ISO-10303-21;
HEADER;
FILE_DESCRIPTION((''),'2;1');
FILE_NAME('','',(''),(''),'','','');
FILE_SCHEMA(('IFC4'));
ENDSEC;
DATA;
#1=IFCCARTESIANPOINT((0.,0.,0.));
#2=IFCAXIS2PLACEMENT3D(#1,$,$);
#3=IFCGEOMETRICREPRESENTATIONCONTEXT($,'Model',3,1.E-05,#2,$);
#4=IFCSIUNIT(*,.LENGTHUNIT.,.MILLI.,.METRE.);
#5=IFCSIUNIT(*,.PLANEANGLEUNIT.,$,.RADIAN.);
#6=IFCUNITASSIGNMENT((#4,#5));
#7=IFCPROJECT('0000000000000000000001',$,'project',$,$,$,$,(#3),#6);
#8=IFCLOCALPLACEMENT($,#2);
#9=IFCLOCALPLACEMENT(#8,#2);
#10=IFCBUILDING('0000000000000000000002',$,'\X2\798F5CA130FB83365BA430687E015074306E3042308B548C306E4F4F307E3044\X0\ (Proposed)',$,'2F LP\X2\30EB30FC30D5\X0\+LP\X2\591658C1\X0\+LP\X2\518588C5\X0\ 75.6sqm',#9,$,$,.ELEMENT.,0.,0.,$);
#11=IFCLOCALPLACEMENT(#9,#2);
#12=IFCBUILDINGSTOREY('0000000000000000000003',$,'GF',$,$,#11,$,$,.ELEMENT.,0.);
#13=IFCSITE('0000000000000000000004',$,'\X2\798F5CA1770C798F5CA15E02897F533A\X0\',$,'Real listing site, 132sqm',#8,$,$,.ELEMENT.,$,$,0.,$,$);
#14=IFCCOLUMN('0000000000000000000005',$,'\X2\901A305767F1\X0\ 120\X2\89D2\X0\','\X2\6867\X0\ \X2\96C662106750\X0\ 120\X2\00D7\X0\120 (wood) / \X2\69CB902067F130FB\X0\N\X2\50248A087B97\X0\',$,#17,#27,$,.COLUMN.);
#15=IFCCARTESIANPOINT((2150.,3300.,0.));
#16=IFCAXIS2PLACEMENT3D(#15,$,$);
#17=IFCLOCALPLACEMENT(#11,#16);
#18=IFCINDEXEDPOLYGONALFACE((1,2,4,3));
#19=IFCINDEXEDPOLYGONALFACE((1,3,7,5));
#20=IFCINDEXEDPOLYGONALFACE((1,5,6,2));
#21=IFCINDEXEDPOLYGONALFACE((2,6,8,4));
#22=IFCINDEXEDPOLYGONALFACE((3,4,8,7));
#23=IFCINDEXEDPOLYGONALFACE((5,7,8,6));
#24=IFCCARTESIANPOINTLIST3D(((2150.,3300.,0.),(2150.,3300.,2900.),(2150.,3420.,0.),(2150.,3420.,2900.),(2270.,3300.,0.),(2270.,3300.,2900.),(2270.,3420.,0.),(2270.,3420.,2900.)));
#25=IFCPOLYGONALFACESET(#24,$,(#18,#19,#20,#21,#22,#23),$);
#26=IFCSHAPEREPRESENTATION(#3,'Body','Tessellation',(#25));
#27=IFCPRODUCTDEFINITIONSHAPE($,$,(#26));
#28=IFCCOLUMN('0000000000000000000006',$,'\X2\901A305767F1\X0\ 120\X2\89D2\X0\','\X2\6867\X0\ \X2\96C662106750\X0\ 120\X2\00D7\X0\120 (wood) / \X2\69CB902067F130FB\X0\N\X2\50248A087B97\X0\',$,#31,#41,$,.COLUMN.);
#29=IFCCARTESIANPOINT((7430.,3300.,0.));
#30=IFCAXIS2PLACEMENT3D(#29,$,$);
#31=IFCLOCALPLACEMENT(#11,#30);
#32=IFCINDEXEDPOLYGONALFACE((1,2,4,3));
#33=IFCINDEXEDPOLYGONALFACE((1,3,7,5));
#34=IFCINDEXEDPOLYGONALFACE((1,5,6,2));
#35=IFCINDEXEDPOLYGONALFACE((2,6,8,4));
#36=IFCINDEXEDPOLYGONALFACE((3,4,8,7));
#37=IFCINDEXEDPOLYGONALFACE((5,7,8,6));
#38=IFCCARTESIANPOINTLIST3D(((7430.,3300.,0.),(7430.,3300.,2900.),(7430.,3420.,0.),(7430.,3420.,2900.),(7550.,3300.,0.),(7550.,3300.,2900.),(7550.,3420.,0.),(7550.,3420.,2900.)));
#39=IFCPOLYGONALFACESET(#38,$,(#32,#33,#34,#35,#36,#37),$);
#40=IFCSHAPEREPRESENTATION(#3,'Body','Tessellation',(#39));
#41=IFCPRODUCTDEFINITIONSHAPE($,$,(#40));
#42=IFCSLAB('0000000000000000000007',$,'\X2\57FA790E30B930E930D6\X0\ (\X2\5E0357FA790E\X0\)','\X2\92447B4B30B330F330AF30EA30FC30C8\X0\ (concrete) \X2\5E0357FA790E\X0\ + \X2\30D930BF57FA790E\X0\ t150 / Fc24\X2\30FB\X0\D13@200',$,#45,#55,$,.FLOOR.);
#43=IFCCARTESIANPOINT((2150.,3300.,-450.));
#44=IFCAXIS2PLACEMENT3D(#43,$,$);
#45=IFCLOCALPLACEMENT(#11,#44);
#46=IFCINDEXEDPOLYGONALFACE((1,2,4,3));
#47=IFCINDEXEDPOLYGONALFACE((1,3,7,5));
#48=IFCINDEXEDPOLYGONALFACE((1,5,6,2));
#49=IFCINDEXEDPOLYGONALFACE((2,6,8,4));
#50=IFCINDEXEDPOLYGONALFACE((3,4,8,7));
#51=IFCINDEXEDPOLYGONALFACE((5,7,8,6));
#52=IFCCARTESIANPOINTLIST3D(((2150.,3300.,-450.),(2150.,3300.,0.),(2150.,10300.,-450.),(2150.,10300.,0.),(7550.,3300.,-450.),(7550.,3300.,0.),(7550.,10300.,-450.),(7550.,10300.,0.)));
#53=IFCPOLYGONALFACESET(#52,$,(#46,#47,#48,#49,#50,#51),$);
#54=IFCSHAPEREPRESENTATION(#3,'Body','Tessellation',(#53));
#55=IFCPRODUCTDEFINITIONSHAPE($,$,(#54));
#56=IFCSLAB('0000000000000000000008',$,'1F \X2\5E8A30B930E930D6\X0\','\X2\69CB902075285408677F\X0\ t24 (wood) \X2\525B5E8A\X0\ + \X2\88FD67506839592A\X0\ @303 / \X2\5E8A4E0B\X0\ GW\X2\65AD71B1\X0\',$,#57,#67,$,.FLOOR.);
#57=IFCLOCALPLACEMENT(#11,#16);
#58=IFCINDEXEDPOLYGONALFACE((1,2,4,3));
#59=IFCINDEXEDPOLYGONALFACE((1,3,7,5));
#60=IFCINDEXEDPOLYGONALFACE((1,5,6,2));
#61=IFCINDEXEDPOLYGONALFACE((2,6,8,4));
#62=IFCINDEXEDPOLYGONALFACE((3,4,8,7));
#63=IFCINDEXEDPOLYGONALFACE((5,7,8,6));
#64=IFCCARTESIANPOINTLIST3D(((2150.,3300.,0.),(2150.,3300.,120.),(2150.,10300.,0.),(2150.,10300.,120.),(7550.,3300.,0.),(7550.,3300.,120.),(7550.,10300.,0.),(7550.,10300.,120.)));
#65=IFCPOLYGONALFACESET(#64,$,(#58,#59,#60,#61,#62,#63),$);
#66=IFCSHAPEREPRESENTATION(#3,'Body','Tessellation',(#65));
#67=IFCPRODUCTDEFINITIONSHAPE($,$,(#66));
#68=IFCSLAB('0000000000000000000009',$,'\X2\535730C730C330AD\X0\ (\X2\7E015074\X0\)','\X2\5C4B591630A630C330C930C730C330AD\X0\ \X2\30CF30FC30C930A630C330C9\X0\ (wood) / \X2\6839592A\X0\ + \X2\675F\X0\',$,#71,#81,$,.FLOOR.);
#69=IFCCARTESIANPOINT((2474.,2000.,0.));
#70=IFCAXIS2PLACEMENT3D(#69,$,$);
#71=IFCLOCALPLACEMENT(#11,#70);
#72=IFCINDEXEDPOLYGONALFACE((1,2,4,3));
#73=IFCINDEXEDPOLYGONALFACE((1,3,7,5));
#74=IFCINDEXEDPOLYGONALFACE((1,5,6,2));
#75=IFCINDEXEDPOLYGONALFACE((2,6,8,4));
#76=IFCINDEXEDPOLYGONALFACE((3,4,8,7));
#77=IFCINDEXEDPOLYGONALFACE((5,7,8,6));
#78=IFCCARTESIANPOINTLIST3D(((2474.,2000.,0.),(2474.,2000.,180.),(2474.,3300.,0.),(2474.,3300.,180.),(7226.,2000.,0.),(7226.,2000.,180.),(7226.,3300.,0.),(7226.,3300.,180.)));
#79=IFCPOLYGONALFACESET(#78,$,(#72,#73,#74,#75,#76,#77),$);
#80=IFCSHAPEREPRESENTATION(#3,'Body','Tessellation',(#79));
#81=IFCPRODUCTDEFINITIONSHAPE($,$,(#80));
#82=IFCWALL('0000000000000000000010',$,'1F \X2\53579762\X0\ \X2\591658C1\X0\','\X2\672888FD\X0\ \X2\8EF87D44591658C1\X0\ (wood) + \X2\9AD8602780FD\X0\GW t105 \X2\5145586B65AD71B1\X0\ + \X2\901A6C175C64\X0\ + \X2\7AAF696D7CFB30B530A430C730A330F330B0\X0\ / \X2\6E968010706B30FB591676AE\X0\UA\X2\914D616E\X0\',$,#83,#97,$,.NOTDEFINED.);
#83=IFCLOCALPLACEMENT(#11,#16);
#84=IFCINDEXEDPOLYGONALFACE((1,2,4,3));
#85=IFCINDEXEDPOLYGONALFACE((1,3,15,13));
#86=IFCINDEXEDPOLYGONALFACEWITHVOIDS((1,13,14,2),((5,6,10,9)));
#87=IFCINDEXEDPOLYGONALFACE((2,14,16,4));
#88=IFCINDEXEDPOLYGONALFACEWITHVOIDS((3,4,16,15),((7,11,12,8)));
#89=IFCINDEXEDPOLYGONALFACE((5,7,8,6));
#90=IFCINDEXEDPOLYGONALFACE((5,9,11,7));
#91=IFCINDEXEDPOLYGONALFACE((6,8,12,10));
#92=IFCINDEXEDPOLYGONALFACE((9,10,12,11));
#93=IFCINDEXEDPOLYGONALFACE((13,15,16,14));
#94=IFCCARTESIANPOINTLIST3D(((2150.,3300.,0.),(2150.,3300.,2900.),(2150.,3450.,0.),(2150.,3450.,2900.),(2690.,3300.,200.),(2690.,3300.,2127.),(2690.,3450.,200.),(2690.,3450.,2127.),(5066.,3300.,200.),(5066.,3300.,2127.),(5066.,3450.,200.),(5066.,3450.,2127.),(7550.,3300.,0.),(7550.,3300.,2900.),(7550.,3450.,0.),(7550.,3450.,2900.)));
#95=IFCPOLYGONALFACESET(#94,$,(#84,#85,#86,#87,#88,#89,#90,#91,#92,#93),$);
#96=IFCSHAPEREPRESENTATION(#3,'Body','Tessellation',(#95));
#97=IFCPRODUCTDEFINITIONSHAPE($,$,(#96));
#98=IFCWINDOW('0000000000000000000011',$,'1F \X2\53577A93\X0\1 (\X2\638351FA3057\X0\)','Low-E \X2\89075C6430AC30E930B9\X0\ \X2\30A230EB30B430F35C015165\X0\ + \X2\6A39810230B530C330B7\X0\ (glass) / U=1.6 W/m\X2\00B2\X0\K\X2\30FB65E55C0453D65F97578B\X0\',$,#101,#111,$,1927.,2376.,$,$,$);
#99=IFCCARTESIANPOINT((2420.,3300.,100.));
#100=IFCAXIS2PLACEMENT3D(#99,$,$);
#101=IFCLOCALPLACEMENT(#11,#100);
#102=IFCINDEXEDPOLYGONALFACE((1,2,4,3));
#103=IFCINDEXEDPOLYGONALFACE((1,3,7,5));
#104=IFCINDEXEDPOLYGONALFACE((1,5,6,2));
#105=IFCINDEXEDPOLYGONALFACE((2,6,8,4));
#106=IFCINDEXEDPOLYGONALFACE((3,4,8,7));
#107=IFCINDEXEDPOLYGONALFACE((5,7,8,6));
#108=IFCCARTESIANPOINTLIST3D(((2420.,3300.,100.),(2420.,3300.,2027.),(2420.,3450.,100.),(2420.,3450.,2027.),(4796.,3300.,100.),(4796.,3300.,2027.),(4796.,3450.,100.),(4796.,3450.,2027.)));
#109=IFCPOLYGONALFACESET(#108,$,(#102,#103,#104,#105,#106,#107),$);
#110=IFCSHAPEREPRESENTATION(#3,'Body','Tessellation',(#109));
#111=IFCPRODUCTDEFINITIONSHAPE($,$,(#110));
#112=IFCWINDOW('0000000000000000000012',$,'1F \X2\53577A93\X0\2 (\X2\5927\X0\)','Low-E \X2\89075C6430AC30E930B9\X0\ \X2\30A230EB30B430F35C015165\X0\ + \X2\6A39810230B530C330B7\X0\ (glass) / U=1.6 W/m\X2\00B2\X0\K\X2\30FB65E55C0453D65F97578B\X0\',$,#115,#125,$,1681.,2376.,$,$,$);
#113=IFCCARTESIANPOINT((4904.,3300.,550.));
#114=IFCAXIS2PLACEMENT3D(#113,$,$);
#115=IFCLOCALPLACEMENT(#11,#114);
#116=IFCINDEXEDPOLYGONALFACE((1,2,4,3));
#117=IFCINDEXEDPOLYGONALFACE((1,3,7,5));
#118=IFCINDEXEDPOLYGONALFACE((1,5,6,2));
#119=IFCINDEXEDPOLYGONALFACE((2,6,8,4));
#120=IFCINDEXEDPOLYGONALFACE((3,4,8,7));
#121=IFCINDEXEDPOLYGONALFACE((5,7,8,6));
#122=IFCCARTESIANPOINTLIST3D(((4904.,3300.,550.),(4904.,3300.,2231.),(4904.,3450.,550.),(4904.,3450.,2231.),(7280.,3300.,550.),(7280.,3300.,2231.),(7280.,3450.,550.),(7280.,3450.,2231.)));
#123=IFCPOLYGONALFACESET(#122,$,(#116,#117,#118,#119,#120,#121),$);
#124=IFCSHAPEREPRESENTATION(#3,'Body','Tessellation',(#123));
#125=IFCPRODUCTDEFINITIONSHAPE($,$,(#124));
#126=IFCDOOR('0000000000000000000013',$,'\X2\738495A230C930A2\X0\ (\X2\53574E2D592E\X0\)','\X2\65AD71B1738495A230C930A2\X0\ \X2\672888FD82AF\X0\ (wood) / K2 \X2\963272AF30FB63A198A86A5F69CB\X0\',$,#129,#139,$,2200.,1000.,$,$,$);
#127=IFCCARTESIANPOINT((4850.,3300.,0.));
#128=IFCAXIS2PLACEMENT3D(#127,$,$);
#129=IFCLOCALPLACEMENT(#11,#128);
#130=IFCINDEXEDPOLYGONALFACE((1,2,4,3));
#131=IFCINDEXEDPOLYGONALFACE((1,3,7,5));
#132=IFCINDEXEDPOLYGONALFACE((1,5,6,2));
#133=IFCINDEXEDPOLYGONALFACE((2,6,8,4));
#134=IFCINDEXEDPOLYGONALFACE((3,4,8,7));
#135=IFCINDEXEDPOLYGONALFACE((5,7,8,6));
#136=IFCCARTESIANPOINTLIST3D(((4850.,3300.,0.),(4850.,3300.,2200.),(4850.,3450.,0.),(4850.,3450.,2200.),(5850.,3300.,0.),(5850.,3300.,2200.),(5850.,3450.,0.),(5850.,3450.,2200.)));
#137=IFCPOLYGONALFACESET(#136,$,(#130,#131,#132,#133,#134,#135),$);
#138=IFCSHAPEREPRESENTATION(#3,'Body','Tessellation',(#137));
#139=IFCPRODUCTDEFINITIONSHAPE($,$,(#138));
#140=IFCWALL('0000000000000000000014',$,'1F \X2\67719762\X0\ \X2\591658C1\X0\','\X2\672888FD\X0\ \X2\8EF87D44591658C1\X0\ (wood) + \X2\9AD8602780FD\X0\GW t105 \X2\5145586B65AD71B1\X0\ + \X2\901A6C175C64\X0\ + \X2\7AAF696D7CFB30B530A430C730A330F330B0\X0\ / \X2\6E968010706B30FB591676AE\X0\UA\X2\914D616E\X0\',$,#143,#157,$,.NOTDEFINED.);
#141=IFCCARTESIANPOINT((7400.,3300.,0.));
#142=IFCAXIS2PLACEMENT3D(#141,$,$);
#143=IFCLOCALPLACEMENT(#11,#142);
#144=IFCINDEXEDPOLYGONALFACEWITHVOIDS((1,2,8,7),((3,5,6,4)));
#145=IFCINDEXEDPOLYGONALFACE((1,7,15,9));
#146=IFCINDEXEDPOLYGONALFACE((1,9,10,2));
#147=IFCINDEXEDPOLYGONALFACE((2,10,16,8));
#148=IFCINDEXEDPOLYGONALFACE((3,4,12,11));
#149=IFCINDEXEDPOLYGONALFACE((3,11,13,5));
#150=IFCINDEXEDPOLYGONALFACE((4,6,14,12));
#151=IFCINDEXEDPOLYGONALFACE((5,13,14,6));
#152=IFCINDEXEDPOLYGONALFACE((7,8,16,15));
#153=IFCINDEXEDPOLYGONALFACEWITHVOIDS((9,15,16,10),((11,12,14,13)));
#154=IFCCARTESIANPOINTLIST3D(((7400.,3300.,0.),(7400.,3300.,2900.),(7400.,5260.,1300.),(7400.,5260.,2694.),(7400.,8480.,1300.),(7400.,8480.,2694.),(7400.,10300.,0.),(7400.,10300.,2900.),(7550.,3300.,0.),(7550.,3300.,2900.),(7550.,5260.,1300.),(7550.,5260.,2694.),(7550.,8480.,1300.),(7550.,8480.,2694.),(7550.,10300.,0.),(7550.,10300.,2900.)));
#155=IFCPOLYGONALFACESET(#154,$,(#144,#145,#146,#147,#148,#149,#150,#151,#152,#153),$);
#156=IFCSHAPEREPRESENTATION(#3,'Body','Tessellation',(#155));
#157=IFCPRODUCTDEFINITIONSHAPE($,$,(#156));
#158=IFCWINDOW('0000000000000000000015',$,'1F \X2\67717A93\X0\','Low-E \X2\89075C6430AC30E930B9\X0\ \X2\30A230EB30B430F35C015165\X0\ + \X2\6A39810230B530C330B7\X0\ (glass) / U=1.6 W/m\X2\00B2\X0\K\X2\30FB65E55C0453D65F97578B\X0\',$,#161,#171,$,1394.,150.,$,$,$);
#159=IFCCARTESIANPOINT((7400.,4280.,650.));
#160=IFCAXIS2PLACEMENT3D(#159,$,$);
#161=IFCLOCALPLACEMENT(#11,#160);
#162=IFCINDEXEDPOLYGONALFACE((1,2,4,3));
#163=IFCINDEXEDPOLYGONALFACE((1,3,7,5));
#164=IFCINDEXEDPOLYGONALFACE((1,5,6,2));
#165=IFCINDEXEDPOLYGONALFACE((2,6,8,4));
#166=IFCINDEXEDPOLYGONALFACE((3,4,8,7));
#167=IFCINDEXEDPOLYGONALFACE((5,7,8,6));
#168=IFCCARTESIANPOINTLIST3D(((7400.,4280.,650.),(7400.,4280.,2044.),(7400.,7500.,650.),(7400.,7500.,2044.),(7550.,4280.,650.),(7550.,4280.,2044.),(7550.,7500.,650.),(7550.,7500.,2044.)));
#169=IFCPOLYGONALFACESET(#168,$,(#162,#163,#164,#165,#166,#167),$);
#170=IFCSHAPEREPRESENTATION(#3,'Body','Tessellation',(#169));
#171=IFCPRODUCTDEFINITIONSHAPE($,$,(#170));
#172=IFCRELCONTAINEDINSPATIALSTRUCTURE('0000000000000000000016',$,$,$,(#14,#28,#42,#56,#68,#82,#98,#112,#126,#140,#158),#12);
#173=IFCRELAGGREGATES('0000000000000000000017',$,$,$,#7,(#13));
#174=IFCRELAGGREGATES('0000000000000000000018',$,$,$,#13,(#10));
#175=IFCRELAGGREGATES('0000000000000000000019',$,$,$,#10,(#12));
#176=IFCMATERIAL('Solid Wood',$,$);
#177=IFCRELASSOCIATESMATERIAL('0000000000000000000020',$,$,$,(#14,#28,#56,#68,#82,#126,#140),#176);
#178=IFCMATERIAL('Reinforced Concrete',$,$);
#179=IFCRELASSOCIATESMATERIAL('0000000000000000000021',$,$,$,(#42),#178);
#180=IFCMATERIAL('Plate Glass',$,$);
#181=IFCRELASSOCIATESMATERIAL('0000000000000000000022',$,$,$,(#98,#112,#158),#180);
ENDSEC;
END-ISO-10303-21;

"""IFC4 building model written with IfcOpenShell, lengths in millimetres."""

from ifc_helpers import new_model, si_unit, frame, frame_2d, origin, place, context, project, spatial, rectangle, extrude, material, element, fill, save


model = new_model("IFC4")

# Units and contexts
model_context = context("Model", 3, precision=1e-05, world=origin())
ifc_project = project(units=[si_unit("LENGTHUNIT", "METRE", prefix="MILLI"), si_unit("PLANEANGLEUNIT", "RADIAN")], contexts=[model_context])

# Site, building, storey
site_placement = place(None, origin())
site = spatial("IfcSite", under=ifc_project, at=site_placement, Name="福岡県福岡市西区", ObjectType="Real listing site, 132sqm", CompositionType="ELEMENT", RefElevation=0.0)
building_placement = place(site_placement, origin())
building = spatial("IfcBuilding", under=site, at=building_placement, Name="福岡・茶室と縁側のある和の住まい (Proposed)", ObjectType="2F LPルーフ+LP外壁+LP内装 75.6sqm", CompositionType="ELEMENT", ElevationOfRefHeight=0.0, ElevationOfTerrain=0.0)
storey_placement = place(building_placement, origin())
storey = spatial("IfcBuildingStorey", under=building, at=storey_placement, Name="GF", CompositionType="ELEMENT", Elevation=0.0)

# Columns
ifc_material_1 = material(Name="Solid Wood")
column_1_placement = place(storey_placement, frame((2150.0, 3300.0, 0.0)))
element("IfcColumn", 1, at=column_1_placement, inside=storey, material=ifc_material_1, Name="通し柱 120角", Description="桧 集成材 120×120 (wood) / 構造柱・N値計算", PredefinedType="COLUMN", context=model_context, shape_type="SweptSolid", body=[
    extrude(rectangle(XDim=120.0, YDim=120.0, at=frame_2d((60.0, 60.0))), frame((2150.0, 3300.0, 0.0)), (0.0, 0.0, 1.0), 2900.0),
])
column_2_placement = place(storey_placement, frame((7430.0, 3300.0, 0.0)))
element("IfcColumn", 2, at=column_2_placement, inside=storey, material=ifc_material_1, Name="通し柱 120角", Description="桧 集成材 120×120 (wood) / 構造柱・N値計算", PredefinedType="COLUMN", context=model_context, shape_type="SweptSolid", body=[
    extrude(rectangle(XDim=120.0, YDim=120.0, at=frame_2d((60.0, 60.0))), frame((7430.0, 3300.0, 0.0)), (0.0, 0.0, 1.0), 2900.0),
])

# Slabs
ifc_material_2 = material(Name="Reinforced Concrete")
slab_1_placement = place(storey_placement, frame((2150.0, 3300.0, -450.0)))
element("IfcSlab", 3, at=slab_1_placement, inside=storey, material=ifc_material_2, Name="基礎スラブ (布基礎)", Description="鉄筋コンクリート (concrete) 布基礎 + ベタ基礎 t150 / Fc24・D13@200", PredefinedType="FLOOR", context=model_context, shape_type="SweptSolid", body=[
    extrude(rectangle(XDim=5400.0, YDim=7000.0, at=frame_2d((2700.0, 3500.0))), frame((2150.0, 3300.0, -450.0)), (0.0, 0.0, 1.0), 450.0),
])
slab_2_placement = place(storey_placement, frame((2150.0, 3300.0, 0.0)))
element("IfcSlab", 4, at=slab_2_placement, inside=storey, material=ifc_material_1, Name="1F 床スラブ", Description="構造用合板 t24 (wood) 剛床 + 製材根太 @303 / 床下 GW断熱", PredefinedType="FLOOR", context=model_context, shape_type="SweptSolid", body=[
    extrude(rectangle(XDim=5400.0, YDim=7000.0, at=frame_2d((2700.0, 3500.0))), frame((2150.0, 3300.0, 0.0)), (0.0, 0.0, 1.0), 120.0),
])
slab_3_placement = place(storey_placement, frame((2474.0, 2000.0, 0.0)))
element("IfcSlab", 5, at=slab_3_placement, inside=storey, material=ifc_material_1, Name="南デッキ (縁側)", Description="屋外ウッドデッキ ハードウッド (wood) / 根太 + 束", PredefinedType="FLOOR", context=model_context, shape_type="SweptSolid", body=[
    extrude(rectangle(XDim=4752.0, YDim=1300.0, at=frame_2d((2376.0, 650.0))), frame((2474.0, 2000.0, 0.0)), (0.0, 0.0, 1.0), 180.0),
])

# Wall, openings, windows, door
wall_1_placement = place(storey_placement, frame((2150.0, 3300.0, 0.0)))
wall_1 = element("IfcWall", 6, at=wall_1_placement, inside=storey, material=ifc_material_1, Name="1F 南面 外壁", Description="木製 軸組外壁 (wood) + 高性能GW t105 充填断熱 + 通気層 + 窯業系サイディング / 準耐火・外皮UA配慮", PredefinedType="NOTDEFINED", context=model_context, shape_type="SweptSolid", body=[
    extrude(rectangle(XDim=5400.0, YDim=150.0, at=frame_2d((2700.0, 75.0))), frame((2150.0, 3300.0, 0.0)), (0.0, 0.0, 1.0), 2900.0),
])
opening_1_placement = place(storey_placement, frame((2420.0, 3300.0, 100.0)))
opening_1 = element("IfcOpeningElement", 7, at=opening_1_placement, cuts=wall_1, PredefinedType="NOTDEFINED", context=model_context, shape_type="SweptSolid", body=[
    extrude(rectangle(XDim=2376.0, YDim=150.0, at=frame_2d((1188.0, 75.0))), frame((2420.0, 3300.0, 100.0)), (0.0, 0.0, 1.0), 1927.0),
])
opening_2_placement = place(storey_placement, frame((4904.0, 3300.0, 550.0)))
opening_2 = element("IfcOpeningElement", 8, at=opening_2_placement, cuts=wall_1, PredefinedType="NOTDEFINED", context=model_context, shape_type="SweptSolid", body=[
    extrude(rectangle(XDim=2376.0, YDim=150.0, at=frame_2d((1188.0, 75.0))), frame((4904.0, 3300.0, 550.0)), (0.0, 0.0, 1.0), 1681.0),
])
opening_3_placement = place(storey_placement, frame((4850.0, 3300.0, 0.0)))
opening_3 = element("IfcOpeningElement", 9, at=opening_3_placement, cuts=wall_1, PredefinedType="NOTDEFINED", context=model_context, shape_type="SweptSolid", body=[
    extrude(rectangle(XDim=1000.0, YDim=150.0, at=frame_2d((500.0, 75.0))), frame((4850.0, 3300.0, 0.0)), (0.0, 0.0, 1.0), 2200.0),
])
ifc_material_3 = material(Name="Plate Glass")
window_1_placement = place(storey_placement, frame((2420.0, 3300.0, 100.0)))
window_1 = element("IfcWindow", 10, at=window_1_placement, inside=storey, material=ifc_material_3, Name="1F 南窓1 (掃出し)", Description="Low-E 複層ガラス アルゴン封入 + 樹脂サッシ (glass) / U=1.6 W/m²K・日射取得型", OverallHeight=1927.0, OverallWidth=2376.0, context=model_context, shape_type="SweptSolid", body=[
    extrude(rectangle(XDim=2376.0, YDim=150.0, at=frame_2d((1188.0, 75.0))), frame((2420.0, 3300.0, 100.0)), (0.0, 0.0, 1.0), 1927.0),
])
fill(opening_1, window_1)
window_2_placement = place(storey_placement, frame((4904.0, 3300.0, 550.0)))
window_2 = element("IfcWindow", 11, at=window_2_placement, inside=storey, material=ifc_material_3, Name="1F 南窓2 (大)", Description="Low-E 複層ガラス アルゴン封入 + 樹脂サッシ (glass) / U=1.6 W/m²K・日射取得型", OverallHeight=1681.0, OverallWidth=2376.0, context=model_context, shape_type="SweptSolid", body=[
    extrude(rectangle(XDim=2376.0, YDim=150.0, at=frame_2d((1188.0, 75.0))), frame((4904.0, 3300.0, 550.0)), (0.0, 0.0, 1.0), 1681.0),
])
fill(opening_2, window_2)
door_placement = place(storey_placement, frame((4850.0, 3300.0, 0.0)))
door = element("IfcDoor", 12, at=door_placement, inside=storey, material=ifc_material_1, Name="玄関ドア (南中央)", Description="断熱玄関ドア 木製芯 (wood) / K2 防犯・採風機構", OverallHeight=2200.0, OverallWidth=1000.0, context=model_context, shape_type="SweptSolid", body=[
    extrude(rectangle(XDim=1000.0, YDim=150.0, at=frame_2d((500.0, 75.0))), frame((4850.0, 3300.0, 0.0)), (0.0, 0.0, 1.0), 2200.0),
])
fill(opening_3, door)

# Wall, opening, window
wall_2_placement = place(storey_placement, frame((7400.0, 3300.0, 0.0)))
wall_2 = element("IfcWall", 13, at=wall_2_placement, inside=storey, material=ifc_material_1, Name="1F 東面 外壁", Description="木製 軸組外壁 (wood) + 高性能GW t105 充填断熱 + 通気層 + 窯業系サイディング / 準耐火・外皮UA配慮", PredefinedType="NOTDEFINED", context=model_context, shape_type="SweptSolid", body=[
    extrude(rectangle(XDim=150.0, YDim=7000.0, at=frame_2d((75.0, 3500.0))), frame((7400.0, 3300.0, 0.0)), (0.0, 0.0, 1.0), 2900.0),
])
opening_4_placement = place(storey_placement, frame((7400.0, 4280.0, 650.0)))
opening_4 = element("IfcOpeningElement", 14, at=opening_4_placement, cuts=wall_2, PredefinedType="NOTDEFINED", context=model_context, shape_type="SweptSolid", body=[
    extrude(rectangle(XDim=150.0, YDim=3220.0, at=frame_2d((75.0, 1610.0))), frame((7400.0, 4280.0, 650.0)), (0.0, 0.0, 1.0), 1394.0),
])
window_3_placement = place(storey_placement, frame((7400.0, 4280.0, 650.0)))
window_3 = element("IfcWindow", 15, at=window_3_placement, inside=storey, material=ifc_material_3, Name="1F 東窓", Description="Low-E 複層ガラス アルゴン封入 + 樹脂サッシ (glass) / U=1.6 W/m²K・日射取得型", OverallHeight=1394.0, OverallWidth=150.0, context=model_context, shape_type="SweptSolid", body=[
    extrude(rectangle(XDim=150.0, YDim=3220.0, at=frame_2d((75.0, 1610.0))), frame((7400.0, 4280.0, 650.0)), (0.0, 0.0, 1.0), 1394.0),
])
fill(opening_4, window_3)

save(model, "model.ifc")
